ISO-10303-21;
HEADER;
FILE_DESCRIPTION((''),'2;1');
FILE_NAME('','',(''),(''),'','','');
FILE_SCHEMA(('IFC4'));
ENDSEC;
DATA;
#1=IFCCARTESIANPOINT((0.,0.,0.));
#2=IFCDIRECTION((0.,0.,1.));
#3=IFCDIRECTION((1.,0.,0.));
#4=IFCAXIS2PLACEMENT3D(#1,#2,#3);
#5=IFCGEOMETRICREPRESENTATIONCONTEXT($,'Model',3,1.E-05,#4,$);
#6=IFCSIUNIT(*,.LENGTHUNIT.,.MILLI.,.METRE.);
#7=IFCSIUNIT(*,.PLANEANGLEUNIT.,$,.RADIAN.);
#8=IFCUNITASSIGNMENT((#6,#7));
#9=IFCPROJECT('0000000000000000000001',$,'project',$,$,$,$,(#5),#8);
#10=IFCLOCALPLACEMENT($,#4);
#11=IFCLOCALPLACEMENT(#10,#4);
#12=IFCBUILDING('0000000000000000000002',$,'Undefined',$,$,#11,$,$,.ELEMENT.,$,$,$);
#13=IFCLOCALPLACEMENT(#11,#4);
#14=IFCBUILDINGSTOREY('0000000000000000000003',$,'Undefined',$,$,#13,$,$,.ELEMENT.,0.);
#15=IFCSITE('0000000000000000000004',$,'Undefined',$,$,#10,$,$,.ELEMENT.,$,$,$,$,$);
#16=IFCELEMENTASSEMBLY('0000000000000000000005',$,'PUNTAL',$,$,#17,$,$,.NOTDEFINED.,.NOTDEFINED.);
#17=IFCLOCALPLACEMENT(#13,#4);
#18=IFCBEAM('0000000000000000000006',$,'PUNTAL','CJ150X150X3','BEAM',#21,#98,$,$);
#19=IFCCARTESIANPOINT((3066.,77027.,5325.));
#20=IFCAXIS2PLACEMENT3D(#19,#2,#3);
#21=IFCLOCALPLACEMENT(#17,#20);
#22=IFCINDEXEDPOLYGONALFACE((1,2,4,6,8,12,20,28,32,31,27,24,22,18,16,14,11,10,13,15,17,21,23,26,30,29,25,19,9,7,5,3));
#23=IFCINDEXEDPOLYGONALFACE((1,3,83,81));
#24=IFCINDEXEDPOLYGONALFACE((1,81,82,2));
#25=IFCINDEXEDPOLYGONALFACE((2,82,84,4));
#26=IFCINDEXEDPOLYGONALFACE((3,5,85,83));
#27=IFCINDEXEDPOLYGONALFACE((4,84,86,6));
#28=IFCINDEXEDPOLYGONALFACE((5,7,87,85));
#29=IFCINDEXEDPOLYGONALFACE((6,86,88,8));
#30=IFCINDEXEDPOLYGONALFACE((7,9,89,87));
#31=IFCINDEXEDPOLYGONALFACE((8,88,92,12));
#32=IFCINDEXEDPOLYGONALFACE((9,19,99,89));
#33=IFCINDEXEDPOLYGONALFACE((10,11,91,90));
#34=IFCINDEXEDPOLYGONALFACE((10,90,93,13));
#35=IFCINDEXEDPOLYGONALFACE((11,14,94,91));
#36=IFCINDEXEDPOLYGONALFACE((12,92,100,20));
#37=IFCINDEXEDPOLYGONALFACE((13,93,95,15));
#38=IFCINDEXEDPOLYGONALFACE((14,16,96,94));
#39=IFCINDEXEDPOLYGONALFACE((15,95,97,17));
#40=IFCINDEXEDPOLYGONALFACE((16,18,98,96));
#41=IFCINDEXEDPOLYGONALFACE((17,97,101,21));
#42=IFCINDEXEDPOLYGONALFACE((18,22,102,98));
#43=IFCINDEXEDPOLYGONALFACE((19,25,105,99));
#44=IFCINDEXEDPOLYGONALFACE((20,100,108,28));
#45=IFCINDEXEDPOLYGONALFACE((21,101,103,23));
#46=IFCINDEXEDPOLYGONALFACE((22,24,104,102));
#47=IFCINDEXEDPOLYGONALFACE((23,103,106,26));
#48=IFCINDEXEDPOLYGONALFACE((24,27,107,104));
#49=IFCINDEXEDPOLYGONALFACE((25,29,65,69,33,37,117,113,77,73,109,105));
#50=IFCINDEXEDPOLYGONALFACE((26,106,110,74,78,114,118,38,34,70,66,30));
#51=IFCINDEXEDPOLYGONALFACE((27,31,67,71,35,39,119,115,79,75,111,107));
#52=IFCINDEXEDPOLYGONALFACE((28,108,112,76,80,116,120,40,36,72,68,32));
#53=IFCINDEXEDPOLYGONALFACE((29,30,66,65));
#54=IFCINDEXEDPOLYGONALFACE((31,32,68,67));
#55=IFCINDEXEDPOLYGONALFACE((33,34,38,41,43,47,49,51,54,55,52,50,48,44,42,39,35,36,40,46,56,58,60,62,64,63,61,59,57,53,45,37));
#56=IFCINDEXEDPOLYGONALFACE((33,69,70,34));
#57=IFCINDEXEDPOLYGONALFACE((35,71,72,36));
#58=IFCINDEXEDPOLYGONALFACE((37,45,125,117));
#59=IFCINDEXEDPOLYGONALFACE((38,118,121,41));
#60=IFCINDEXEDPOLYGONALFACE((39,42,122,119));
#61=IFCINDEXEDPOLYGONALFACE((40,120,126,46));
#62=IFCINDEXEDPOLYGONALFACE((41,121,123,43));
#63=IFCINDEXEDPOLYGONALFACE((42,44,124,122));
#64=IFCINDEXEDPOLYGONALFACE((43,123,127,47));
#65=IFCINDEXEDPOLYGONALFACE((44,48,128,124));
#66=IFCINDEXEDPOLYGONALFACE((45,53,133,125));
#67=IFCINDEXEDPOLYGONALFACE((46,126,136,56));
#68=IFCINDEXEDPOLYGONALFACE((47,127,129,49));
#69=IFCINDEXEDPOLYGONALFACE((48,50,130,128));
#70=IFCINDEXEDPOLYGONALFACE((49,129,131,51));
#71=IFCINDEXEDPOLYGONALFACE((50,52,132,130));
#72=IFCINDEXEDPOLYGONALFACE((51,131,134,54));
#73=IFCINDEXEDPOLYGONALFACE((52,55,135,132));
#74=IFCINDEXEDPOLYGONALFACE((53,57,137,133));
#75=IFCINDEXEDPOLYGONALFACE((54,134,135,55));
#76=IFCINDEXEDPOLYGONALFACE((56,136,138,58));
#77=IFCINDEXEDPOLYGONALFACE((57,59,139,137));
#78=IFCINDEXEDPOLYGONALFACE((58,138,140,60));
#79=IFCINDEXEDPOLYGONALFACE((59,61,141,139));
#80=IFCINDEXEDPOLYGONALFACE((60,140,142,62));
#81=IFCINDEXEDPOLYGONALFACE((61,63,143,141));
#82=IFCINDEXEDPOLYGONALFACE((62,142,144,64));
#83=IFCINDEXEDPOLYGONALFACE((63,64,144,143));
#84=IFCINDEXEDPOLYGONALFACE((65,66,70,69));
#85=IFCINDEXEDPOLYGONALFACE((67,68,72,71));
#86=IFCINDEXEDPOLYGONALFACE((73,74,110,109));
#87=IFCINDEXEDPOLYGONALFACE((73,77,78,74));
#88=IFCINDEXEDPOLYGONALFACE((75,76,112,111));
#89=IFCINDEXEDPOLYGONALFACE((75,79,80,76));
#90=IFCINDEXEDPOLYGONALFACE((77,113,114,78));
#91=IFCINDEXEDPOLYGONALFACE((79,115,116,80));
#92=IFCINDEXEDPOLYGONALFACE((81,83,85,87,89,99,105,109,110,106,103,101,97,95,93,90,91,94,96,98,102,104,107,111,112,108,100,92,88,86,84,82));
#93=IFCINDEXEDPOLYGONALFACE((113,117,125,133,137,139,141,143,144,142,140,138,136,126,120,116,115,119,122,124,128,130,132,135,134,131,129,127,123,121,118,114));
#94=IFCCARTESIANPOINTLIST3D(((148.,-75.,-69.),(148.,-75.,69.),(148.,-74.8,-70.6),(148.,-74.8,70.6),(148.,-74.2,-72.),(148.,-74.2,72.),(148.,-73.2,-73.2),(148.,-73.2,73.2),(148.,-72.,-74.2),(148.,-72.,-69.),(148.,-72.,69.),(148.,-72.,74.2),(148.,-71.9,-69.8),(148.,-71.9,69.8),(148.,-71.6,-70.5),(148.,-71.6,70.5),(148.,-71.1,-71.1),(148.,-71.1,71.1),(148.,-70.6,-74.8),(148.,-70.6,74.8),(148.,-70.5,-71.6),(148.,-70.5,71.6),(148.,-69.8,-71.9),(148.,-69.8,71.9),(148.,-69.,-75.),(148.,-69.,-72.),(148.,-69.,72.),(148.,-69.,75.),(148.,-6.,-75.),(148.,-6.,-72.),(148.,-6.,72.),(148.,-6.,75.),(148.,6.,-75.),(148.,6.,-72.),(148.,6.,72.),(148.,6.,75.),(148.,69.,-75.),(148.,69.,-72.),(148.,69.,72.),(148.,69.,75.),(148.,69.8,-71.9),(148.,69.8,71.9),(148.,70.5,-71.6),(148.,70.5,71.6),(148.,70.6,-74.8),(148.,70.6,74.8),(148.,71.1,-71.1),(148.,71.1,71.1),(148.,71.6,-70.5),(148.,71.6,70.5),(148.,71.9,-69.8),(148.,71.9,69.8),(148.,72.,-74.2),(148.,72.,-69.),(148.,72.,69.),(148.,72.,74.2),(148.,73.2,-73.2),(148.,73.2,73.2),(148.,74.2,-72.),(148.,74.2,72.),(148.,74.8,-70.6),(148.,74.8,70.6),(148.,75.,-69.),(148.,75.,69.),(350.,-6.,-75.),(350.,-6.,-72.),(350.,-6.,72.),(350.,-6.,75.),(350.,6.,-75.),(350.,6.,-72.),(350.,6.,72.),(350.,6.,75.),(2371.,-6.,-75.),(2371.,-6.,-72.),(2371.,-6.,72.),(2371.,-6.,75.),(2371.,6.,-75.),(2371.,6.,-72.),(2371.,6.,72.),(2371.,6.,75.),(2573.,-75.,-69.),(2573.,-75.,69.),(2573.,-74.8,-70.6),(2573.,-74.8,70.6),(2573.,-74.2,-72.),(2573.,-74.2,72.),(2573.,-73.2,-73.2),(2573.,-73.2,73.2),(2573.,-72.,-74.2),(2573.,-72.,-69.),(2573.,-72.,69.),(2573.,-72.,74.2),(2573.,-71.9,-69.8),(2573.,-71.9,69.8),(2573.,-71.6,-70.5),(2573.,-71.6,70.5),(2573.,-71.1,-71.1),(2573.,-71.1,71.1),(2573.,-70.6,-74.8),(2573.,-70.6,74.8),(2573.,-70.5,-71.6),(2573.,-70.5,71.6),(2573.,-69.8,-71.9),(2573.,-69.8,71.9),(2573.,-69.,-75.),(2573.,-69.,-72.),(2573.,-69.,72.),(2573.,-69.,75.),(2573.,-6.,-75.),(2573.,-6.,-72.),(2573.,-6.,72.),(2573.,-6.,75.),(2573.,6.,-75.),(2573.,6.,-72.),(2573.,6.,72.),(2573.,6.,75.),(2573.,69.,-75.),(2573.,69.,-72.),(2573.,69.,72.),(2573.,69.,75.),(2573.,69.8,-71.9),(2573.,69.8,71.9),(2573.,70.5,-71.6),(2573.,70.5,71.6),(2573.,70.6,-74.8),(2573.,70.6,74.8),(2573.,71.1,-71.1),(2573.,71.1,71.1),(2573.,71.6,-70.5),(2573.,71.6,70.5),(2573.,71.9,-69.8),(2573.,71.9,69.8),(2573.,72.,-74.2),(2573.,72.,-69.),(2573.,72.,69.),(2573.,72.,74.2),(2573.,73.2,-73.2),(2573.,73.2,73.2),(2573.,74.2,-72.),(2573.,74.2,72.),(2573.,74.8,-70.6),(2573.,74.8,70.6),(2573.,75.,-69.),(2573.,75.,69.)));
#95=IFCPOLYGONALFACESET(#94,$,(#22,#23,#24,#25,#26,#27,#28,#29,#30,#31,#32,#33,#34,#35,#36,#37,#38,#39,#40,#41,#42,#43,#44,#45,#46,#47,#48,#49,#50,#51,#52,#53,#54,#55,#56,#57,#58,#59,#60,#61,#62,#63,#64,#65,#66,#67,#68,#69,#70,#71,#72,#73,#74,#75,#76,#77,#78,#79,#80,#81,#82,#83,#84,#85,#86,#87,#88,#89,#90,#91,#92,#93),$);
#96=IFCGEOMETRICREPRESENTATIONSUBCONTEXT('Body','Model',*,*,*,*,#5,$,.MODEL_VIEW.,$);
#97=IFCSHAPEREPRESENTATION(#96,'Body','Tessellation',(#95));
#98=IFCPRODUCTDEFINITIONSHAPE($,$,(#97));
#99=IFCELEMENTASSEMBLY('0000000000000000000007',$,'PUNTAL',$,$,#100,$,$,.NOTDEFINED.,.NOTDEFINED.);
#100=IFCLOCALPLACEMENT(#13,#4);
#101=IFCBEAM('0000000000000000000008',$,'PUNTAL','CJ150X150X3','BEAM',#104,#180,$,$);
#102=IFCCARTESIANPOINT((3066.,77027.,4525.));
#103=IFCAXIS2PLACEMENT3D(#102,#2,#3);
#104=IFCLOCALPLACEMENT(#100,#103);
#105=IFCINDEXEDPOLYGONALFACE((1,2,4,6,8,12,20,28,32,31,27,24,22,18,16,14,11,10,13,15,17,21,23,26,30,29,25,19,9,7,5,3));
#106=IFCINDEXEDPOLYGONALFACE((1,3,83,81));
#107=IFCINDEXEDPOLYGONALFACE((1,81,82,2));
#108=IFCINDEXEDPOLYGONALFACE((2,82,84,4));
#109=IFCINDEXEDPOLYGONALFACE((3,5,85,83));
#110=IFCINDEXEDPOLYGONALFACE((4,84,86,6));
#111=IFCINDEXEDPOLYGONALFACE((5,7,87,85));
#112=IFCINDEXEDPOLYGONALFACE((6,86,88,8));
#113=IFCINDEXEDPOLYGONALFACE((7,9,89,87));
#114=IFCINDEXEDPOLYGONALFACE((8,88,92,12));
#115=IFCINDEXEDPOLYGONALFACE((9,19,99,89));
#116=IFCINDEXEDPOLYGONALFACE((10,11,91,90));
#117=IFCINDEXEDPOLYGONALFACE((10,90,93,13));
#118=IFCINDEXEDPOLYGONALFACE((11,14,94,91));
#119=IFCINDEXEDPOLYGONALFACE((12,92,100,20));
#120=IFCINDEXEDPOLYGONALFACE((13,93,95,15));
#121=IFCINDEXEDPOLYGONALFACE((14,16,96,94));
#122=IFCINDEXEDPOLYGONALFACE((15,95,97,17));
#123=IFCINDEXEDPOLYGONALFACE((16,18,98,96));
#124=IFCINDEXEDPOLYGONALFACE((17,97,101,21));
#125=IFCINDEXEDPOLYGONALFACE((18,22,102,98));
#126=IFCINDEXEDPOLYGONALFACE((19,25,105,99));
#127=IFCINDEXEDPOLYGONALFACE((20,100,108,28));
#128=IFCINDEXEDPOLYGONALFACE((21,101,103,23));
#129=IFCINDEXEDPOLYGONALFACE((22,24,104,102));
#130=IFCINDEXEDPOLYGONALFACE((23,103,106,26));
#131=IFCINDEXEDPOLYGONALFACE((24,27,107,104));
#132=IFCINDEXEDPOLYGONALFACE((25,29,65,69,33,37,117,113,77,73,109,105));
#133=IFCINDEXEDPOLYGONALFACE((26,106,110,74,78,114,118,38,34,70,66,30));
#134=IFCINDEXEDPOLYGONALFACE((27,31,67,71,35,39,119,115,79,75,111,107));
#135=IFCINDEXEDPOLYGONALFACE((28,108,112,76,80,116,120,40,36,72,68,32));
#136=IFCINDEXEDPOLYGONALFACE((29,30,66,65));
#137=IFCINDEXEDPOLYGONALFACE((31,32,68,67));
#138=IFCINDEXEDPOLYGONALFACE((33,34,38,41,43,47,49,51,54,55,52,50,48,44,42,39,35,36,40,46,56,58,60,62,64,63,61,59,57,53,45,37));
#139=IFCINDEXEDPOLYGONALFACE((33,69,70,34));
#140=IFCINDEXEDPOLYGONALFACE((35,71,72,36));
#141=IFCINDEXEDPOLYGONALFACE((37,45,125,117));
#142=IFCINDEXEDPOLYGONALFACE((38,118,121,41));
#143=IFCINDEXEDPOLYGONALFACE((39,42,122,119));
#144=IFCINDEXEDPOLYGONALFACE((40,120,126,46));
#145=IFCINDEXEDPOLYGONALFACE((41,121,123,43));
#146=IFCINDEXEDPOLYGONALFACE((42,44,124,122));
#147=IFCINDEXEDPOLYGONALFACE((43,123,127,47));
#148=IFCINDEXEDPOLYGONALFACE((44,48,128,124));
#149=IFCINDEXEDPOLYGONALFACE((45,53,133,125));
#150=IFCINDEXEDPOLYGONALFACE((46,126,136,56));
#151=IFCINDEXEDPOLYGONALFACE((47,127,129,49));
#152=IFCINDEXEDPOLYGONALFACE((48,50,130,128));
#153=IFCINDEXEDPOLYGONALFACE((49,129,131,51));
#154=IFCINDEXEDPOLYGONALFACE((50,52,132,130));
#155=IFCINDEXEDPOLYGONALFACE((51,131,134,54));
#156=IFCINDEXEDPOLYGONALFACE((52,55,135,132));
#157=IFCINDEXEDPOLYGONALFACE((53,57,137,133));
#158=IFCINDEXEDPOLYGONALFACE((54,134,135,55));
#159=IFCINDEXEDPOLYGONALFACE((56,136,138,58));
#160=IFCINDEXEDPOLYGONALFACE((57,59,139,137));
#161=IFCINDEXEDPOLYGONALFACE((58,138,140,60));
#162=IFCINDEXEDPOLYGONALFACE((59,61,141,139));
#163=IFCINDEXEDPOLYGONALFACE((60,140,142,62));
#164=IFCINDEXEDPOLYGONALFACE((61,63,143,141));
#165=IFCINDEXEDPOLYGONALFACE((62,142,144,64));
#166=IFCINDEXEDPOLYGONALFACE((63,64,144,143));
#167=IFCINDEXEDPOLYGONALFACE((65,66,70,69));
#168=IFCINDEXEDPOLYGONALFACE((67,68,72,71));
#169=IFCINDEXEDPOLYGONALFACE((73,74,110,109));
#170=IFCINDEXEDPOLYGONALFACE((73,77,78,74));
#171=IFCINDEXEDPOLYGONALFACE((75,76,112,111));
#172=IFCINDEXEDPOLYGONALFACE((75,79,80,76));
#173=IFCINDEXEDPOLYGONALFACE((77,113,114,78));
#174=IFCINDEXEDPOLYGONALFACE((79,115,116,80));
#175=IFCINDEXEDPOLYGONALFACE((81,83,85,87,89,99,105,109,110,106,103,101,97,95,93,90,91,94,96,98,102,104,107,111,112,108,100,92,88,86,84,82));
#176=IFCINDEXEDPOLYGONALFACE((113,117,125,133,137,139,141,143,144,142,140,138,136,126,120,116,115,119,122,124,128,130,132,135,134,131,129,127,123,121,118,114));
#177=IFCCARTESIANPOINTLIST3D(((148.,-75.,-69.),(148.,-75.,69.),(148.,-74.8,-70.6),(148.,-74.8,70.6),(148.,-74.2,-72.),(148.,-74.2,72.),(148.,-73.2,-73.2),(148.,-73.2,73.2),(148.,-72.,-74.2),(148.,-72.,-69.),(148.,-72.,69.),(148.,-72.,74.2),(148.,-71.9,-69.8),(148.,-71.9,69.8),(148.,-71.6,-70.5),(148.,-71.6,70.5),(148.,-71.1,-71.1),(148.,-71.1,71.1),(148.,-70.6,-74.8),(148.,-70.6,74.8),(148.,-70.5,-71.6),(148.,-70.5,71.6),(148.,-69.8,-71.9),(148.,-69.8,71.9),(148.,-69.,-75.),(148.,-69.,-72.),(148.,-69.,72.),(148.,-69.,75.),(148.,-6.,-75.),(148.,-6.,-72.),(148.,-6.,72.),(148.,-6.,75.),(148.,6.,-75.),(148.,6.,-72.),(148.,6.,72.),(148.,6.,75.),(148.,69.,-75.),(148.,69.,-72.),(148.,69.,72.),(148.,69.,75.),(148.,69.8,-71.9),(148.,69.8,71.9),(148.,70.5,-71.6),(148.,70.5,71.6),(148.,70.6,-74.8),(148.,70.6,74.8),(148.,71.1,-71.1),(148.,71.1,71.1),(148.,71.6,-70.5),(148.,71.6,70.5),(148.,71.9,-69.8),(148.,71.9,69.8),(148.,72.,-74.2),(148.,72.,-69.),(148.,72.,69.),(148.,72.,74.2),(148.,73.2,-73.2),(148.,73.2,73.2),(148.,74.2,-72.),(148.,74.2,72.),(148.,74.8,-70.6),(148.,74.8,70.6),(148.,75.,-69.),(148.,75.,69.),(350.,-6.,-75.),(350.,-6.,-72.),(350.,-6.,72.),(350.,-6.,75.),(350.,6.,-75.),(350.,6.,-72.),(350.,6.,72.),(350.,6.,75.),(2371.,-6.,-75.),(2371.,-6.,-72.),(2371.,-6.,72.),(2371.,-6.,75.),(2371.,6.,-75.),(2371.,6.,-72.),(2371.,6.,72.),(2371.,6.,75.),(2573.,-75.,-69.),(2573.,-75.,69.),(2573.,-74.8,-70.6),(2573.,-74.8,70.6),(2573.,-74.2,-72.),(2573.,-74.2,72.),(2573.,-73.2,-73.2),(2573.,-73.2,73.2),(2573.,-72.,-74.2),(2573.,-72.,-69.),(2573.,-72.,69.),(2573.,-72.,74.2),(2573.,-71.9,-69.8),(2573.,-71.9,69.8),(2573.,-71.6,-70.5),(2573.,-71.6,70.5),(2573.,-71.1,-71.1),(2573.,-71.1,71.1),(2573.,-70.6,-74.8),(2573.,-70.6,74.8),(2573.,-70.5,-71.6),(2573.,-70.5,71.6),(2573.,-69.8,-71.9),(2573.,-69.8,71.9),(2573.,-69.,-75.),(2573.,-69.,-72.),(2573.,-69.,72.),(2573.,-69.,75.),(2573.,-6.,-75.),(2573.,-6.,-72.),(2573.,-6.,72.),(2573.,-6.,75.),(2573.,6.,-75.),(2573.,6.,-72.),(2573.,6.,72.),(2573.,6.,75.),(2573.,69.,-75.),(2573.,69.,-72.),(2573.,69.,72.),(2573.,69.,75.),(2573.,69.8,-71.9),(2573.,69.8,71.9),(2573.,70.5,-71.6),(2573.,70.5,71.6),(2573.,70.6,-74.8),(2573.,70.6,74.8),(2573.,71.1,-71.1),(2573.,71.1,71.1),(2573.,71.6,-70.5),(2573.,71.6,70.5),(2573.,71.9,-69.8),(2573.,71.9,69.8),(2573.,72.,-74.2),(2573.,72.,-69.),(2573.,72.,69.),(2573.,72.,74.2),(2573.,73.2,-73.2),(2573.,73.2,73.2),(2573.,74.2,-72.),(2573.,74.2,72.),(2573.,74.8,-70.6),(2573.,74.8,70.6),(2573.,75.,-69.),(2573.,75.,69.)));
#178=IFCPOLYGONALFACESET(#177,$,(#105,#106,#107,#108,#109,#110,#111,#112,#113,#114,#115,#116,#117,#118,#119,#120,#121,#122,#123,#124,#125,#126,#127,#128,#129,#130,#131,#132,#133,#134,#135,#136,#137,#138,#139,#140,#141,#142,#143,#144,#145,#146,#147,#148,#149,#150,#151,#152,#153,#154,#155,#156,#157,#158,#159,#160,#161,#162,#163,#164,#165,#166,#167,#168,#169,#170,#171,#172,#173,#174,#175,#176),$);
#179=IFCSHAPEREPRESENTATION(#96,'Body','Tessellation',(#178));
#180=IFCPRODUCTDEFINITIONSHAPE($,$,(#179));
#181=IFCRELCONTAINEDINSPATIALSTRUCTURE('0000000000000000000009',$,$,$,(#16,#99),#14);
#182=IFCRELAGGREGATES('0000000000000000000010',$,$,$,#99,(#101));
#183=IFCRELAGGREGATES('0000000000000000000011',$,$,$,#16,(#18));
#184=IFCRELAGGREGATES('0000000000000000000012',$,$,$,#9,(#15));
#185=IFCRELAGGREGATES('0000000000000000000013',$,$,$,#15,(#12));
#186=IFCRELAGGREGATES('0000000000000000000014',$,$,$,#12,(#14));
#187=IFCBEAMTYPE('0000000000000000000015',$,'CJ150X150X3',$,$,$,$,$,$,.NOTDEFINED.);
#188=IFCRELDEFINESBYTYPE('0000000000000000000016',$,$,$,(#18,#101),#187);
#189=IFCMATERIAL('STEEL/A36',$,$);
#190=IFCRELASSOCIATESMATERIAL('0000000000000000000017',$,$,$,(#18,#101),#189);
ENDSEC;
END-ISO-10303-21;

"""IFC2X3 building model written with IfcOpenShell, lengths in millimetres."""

from ifc_helpers import new_model, si_unit, frame, origin_with_axes, origin_2d_with_axis, place, context, subcontext, project, spatial, rectangle, hollow_rectangle, extrude, boolean, halfspace, material, type_object, element, aggregate, save


model = new_model("IFC2X3")

# Units and contexts
model_context = context("Model", 3, precision=1e-05, world=origin_with_axes())
body_context = subcontext(model_context, "Body", "Model", "MODEL_VIEW")
ifc_project = project(units=[si_unit("LENGTHUNIT", "METRE", prefix="MILLI"), si_unit("PLANEANGLEUNIT", "RADIAN")], contexts=[model_context])

# Site, building, storey
site_placement = place(None, origin_with_axes())
site = spatial("IfcSite", under=ifc_project, at=site_placement, Name="Undefined", CompositionType="ELEMENT")
building_placement = place(site_placement, origin_with_axes())
building = spatial("IfcBuilding", under=site, at=building_placement, Name="Undefined", CompositionType="ELEMENT")
storey_placement = place(building_placement, origin_with_axes())
storey = spatial("IfcBuildingStorey", under=building, at=storey_placement, Name="Undefined", CompositionType="ELEMENT", Elevation=0.0)

# Element assemblies, beams
ifc_material_1 = material(Name="STEEL/A36")
assembly_1_placement = place(storey_placement, origin_with_axes())
assembly_1 = element("IfcElementAssembly", 1, at=assembly_1_placement, inside=storey, Name="PUNTAL", AssemblyPlace="NOTDEFINED", PredefinedType="NOTDEFINED")
beam_type_1 = type_object("IfcBeamType", Name="CJ150X150X3", PredefinedType="NOTDEFINED")
beam_1_placement = place(assembly_1_placement, frame((3066.0, 77027.0, 5325.0), z_axis=(0.0, 0.0, 1.0), x_axis=(1.0, 0.0, 0.0)))
beam_1 = element("IfcBeam", 2, at=beam_1_placement, type_object=beam_type_1, material=ifc_material_1, Name="PUNTAL", Description="CJ150X150X3", ObjectType="BEAM", context=body_context, shape_type="CSG", body=[
    boolean("DIFFERENCE", boolean("DIFFERENCE", boolean("DIFFERENCE", boolean("DIFFERENCE", extrude(hollow_rectangle(XDim=150.0, YDim=150.0, WallThickness=3.0, InnerFilletRadius=3.0, OuterFilletRadius=6.0, at=origin_2d_with_axis()), frame((2721.0, 0.0, 0.0), z_axis=(-1.0, 0.0, 0.0), x_axis=(0.0, -1.0, 0.0)), (0.0, 0.0, 1.0), 2721.0), extrude(rectangle(XDim=12.0, YDim=154.0, at=origin_2d_with_axis()), frame((2371.0, 0.0, 0.0), z_axis=(1.0, 0.0, 0.0), x_axis=(0.0, -1.0, 0.0)), (0.0, 0.0, 1.0), 214.0)), extrude(rectangle(XDim=12.0, YDim=154.0, at=origin_2d_with_axis()), frame((350.0, 0.0, 0.0), z_axis=(-1.0, 0.0, 0.0), x_axis=(0.0, 1.0, 0.0)), (0.0, 0.0, 1.0), 214.0)), halfspace(frame((2573.0, 15.0, 0.0), z_axis=(-1.0, 0.0, 0.0), x_axis=(0.0, -1.0, 0.0)), True)), halfspace(frame((148.0, 15.0, 0.0), z_axis=(1.0, 0.0, 0.0), x_axis=(0.0, 0.0, -1.0)), True)),
])
assembly_2_placement = place(storey_placement, origin_with_axes())
assembly_2 = element("IfcElementAssembly", 3, at=assembly_2_placement, inside=storey, Name="PUNTAL", AssemblyPlace="NOTDEFINED", PredefinedType="NOTDEFINED")
beam_2_placement = place(assembly_2_placement, frame((3066.0, 77027.0, 4525.0), z_axis=(0.0, 0.0, 1.0), x_axis=(1.0, 0.0, 0.0)))
beam_2 = element("IfcBeam", 4, at=beam_2_placement, type_object=beam_type_1, material=ifc_material_1, Name="PUNTAL", Description="CJ150X150X3", ObjectType="BEAM", context=body_context, shape_type="CSG", body=[
    boolean("DIFFERENCE", boolean("DIFFERENCE", boolean("DIFFERENCE", boolean("DIFFERENCE", extrude(hollow_rectangle(XDim=150.0, YDim=150.0, WallThickness=3.0, InnerFilletRadius=3.0, OuterFilletRadius=6.0, at=origin_2d_with_axis()), frame((2721.0, 0.0, 0.0), z_axis=(-1.0, 0.0, 0.0), x_axis=(0.0, -1.0, 0.0)), (0.0, 0.0, 1.0), 2721.0), extrude(rectangle(XDim=12.0, YDim=154.0, at=origin_2d_with_axis()), frame((2371.0, 0.0, 0.0), z_axis=(1.0, 0.0, 0.0), x_axis=(0.0, 1.0, 0.0)), (0.0, 0.0, 1.0), 225.0)), extrude(rectangle(XDim=12.0, YDim=154.0, at=origin_2d_with_axis()), frame((350.0, 0.0, 0.0), z_axis=(-1.0, 0.0, 0.0), x_axis=(0.0, -1.0, 0.0)), (0.0, 0.0, 1.0), 225.0)), halfspace(frame((2573.0, -15.0, 0.0), z_axis=(-1.0, 0.0, 0.0), x_axis=(0.0, 1.0, 0.0)), True)), halfspace(frame((148.0, -15.0, 0.0), z_axis=(1.0, 0.0, 0.0), x_axis=(0.0, 0.0, 1.0)), True)),
])

aggregate(assembly_2, [beam_2])
aggregate(assembly_1, [beam_1])

save(model, "model.ifc")
